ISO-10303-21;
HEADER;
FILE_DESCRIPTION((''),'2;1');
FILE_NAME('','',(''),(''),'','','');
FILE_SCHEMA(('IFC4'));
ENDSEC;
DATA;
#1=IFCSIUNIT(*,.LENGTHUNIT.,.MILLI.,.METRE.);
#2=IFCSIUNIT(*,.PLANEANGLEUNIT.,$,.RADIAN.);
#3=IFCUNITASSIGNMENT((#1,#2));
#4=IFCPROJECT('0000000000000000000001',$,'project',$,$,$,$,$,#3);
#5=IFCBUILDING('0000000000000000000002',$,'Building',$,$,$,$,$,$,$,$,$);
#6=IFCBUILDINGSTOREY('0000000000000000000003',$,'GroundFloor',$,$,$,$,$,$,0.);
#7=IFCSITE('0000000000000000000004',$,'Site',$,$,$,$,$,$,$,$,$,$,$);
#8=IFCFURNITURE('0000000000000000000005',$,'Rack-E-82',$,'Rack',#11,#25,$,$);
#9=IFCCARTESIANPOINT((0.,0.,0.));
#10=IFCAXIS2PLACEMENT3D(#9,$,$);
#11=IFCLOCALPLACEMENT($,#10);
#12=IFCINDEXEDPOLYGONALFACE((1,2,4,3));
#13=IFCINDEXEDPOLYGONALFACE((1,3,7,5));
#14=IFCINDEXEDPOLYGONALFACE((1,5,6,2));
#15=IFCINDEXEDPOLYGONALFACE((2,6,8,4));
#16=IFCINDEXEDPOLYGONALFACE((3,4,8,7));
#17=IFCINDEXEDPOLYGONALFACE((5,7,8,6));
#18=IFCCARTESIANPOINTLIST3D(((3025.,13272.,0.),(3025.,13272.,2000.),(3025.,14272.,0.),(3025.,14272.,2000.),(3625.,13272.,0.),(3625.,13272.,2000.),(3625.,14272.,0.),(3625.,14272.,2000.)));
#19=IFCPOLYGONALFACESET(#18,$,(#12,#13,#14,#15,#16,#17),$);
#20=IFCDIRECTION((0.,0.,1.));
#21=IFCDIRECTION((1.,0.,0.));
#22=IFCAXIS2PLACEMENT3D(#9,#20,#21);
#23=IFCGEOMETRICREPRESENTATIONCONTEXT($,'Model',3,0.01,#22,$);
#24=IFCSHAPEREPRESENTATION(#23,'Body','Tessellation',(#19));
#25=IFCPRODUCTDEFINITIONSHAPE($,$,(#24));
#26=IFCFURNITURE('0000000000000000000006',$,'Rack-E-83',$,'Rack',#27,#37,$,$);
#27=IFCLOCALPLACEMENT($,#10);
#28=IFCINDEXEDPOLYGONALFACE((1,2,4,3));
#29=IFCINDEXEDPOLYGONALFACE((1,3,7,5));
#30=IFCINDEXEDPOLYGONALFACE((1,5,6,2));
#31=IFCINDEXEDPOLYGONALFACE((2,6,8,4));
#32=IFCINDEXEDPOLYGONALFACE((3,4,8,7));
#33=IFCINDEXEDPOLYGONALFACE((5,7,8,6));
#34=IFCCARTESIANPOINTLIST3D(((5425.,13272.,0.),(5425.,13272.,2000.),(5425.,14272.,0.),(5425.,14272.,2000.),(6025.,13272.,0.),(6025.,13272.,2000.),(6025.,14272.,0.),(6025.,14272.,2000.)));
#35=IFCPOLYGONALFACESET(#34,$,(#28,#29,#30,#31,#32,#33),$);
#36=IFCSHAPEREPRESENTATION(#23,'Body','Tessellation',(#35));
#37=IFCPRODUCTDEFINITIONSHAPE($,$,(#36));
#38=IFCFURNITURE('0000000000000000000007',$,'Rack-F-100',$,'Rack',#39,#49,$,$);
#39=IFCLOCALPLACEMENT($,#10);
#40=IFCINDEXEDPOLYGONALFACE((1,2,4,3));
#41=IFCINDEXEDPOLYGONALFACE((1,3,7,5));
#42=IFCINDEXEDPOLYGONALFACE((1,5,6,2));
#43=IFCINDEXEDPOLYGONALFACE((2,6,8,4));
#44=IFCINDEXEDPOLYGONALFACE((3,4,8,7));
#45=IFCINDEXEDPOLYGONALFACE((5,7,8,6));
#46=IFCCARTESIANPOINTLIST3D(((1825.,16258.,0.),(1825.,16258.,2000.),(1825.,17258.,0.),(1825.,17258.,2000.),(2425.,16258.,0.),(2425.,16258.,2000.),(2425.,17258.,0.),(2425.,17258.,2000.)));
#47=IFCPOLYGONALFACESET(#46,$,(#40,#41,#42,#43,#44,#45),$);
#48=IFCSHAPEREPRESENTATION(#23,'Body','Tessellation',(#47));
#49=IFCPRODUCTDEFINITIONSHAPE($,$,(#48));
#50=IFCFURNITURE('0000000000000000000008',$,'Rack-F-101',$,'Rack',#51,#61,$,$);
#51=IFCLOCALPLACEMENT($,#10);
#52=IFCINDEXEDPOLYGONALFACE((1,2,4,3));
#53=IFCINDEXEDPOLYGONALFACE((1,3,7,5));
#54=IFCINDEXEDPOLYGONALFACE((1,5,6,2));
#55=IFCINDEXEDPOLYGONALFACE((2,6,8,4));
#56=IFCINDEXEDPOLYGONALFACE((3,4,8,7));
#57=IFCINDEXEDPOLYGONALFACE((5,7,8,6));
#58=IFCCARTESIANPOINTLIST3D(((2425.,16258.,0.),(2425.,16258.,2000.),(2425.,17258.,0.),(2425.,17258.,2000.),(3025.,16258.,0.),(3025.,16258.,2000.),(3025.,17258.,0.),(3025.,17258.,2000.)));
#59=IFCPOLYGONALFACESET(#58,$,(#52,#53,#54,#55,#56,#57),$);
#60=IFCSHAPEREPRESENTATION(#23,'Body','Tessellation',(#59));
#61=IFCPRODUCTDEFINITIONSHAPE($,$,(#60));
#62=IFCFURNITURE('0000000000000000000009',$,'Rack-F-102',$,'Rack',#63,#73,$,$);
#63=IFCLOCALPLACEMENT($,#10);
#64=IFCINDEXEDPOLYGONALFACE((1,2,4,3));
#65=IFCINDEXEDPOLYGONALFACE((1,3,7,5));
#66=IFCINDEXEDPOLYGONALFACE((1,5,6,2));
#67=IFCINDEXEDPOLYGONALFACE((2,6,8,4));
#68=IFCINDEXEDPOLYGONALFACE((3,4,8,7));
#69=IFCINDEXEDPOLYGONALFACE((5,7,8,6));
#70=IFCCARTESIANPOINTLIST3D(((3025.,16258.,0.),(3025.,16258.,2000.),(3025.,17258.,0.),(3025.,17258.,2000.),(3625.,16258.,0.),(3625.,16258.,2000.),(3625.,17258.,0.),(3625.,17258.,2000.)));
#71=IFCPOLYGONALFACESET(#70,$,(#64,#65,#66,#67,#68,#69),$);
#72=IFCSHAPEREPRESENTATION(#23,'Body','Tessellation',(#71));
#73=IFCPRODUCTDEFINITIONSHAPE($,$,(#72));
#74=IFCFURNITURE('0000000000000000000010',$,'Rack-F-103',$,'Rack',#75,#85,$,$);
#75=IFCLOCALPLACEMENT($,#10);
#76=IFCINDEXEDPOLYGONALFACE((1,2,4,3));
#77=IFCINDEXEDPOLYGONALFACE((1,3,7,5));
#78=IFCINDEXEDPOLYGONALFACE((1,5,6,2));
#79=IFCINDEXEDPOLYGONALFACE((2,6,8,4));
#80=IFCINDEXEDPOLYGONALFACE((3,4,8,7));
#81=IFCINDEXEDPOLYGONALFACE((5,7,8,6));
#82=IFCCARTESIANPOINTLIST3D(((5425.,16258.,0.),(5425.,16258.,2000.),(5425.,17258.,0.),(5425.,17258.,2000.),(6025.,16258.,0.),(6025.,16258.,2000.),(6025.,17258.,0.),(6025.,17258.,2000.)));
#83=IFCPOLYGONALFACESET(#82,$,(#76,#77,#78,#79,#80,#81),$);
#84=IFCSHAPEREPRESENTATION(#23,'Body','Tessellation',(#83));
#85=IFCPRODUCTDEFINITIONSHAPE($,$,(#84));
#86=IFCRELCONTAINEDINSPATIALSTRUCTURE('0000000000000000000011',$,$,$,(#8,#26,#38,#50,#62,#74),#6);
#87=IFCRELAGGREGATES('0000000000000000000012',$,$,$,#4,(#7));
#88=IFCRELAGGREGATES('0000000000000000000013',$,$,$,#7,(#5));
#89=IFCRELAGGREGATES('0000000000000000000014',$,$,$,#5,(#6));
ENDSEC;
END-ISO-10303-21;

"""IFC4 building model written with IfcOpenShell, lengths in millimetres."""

from ifc_helpers import new_model, si_unit, frame, origin, origin_with_axes, origin_2d, place, context, project, spatial, rectangle, extrude, element, save


model = new_model("IFC4")

# Units and contexts
model_context = context("Model", 3, precision=0.01, world=origin_with_axes())
ifc_project = project(units=[si_unit("LENGTHUNIT", "METRE", prefix="MILLI"), si_unit("PLANEANGLEUNIT", "RADIAN")])

# Site, building, storey
site = spatial("IfcSite", under=ifc_project, Name="Site")
building = spatial("IfcBuilding", under=site, Name="Building")
storey = spatial("IfcBuildingStorey", under=building, Name="GroundFloor", Elevation=0.0)

# Furniture
for number, where, z_axis, x_axis, name in (
    (1, (3325.0, 13772.0, 0.0), (0.0, 0.0, 1.0), (1.0, 0.0, 0.0), "Rack-E-82"),
    (2, (5725.0, 13772.0, 0.0), (0.0, 0.0, 1.0), (1.0, 0.0, 0.0), "Rack-E-83"),
    (3, (2125.0, 16758.0, 0.0), (0.0, 0.0, 1.0), (1.0, 0.0, 0.0), "Rack-F-100"),
    (4, (2725.0, 16758.0, 0.0), (0.0, 0.0, 1.0), (1.0, 0.0, 0.0), "Rack-F-101"),
    (5, (3325.0, 16758.0, 0.0), (0.0, 0.0, 1.0), (1.0, 0.0, 0.0), "Rack-F-102"),
    (6, (5725.0, 16758.0, 0.0), (0.0, 0.0, 1.0), (1.0, 0.0, 0.0), "Rack-F-103"),
):
    element("IfcFurniture", number, at=place(None, frame(where, z_axis=z_axis, x_axis=x_axis)), inside=storey, Name=name, ObjectType="Rack", context=model_context, shape_type="SweptSolid", body=[
        extrude(rectangle(XDim=600.0, YDim=1000.0, at=origin_2d()), origin(), (0.0, 0.0, 1.0), 2000.0),
    ])

save(model, "model.ifc")
